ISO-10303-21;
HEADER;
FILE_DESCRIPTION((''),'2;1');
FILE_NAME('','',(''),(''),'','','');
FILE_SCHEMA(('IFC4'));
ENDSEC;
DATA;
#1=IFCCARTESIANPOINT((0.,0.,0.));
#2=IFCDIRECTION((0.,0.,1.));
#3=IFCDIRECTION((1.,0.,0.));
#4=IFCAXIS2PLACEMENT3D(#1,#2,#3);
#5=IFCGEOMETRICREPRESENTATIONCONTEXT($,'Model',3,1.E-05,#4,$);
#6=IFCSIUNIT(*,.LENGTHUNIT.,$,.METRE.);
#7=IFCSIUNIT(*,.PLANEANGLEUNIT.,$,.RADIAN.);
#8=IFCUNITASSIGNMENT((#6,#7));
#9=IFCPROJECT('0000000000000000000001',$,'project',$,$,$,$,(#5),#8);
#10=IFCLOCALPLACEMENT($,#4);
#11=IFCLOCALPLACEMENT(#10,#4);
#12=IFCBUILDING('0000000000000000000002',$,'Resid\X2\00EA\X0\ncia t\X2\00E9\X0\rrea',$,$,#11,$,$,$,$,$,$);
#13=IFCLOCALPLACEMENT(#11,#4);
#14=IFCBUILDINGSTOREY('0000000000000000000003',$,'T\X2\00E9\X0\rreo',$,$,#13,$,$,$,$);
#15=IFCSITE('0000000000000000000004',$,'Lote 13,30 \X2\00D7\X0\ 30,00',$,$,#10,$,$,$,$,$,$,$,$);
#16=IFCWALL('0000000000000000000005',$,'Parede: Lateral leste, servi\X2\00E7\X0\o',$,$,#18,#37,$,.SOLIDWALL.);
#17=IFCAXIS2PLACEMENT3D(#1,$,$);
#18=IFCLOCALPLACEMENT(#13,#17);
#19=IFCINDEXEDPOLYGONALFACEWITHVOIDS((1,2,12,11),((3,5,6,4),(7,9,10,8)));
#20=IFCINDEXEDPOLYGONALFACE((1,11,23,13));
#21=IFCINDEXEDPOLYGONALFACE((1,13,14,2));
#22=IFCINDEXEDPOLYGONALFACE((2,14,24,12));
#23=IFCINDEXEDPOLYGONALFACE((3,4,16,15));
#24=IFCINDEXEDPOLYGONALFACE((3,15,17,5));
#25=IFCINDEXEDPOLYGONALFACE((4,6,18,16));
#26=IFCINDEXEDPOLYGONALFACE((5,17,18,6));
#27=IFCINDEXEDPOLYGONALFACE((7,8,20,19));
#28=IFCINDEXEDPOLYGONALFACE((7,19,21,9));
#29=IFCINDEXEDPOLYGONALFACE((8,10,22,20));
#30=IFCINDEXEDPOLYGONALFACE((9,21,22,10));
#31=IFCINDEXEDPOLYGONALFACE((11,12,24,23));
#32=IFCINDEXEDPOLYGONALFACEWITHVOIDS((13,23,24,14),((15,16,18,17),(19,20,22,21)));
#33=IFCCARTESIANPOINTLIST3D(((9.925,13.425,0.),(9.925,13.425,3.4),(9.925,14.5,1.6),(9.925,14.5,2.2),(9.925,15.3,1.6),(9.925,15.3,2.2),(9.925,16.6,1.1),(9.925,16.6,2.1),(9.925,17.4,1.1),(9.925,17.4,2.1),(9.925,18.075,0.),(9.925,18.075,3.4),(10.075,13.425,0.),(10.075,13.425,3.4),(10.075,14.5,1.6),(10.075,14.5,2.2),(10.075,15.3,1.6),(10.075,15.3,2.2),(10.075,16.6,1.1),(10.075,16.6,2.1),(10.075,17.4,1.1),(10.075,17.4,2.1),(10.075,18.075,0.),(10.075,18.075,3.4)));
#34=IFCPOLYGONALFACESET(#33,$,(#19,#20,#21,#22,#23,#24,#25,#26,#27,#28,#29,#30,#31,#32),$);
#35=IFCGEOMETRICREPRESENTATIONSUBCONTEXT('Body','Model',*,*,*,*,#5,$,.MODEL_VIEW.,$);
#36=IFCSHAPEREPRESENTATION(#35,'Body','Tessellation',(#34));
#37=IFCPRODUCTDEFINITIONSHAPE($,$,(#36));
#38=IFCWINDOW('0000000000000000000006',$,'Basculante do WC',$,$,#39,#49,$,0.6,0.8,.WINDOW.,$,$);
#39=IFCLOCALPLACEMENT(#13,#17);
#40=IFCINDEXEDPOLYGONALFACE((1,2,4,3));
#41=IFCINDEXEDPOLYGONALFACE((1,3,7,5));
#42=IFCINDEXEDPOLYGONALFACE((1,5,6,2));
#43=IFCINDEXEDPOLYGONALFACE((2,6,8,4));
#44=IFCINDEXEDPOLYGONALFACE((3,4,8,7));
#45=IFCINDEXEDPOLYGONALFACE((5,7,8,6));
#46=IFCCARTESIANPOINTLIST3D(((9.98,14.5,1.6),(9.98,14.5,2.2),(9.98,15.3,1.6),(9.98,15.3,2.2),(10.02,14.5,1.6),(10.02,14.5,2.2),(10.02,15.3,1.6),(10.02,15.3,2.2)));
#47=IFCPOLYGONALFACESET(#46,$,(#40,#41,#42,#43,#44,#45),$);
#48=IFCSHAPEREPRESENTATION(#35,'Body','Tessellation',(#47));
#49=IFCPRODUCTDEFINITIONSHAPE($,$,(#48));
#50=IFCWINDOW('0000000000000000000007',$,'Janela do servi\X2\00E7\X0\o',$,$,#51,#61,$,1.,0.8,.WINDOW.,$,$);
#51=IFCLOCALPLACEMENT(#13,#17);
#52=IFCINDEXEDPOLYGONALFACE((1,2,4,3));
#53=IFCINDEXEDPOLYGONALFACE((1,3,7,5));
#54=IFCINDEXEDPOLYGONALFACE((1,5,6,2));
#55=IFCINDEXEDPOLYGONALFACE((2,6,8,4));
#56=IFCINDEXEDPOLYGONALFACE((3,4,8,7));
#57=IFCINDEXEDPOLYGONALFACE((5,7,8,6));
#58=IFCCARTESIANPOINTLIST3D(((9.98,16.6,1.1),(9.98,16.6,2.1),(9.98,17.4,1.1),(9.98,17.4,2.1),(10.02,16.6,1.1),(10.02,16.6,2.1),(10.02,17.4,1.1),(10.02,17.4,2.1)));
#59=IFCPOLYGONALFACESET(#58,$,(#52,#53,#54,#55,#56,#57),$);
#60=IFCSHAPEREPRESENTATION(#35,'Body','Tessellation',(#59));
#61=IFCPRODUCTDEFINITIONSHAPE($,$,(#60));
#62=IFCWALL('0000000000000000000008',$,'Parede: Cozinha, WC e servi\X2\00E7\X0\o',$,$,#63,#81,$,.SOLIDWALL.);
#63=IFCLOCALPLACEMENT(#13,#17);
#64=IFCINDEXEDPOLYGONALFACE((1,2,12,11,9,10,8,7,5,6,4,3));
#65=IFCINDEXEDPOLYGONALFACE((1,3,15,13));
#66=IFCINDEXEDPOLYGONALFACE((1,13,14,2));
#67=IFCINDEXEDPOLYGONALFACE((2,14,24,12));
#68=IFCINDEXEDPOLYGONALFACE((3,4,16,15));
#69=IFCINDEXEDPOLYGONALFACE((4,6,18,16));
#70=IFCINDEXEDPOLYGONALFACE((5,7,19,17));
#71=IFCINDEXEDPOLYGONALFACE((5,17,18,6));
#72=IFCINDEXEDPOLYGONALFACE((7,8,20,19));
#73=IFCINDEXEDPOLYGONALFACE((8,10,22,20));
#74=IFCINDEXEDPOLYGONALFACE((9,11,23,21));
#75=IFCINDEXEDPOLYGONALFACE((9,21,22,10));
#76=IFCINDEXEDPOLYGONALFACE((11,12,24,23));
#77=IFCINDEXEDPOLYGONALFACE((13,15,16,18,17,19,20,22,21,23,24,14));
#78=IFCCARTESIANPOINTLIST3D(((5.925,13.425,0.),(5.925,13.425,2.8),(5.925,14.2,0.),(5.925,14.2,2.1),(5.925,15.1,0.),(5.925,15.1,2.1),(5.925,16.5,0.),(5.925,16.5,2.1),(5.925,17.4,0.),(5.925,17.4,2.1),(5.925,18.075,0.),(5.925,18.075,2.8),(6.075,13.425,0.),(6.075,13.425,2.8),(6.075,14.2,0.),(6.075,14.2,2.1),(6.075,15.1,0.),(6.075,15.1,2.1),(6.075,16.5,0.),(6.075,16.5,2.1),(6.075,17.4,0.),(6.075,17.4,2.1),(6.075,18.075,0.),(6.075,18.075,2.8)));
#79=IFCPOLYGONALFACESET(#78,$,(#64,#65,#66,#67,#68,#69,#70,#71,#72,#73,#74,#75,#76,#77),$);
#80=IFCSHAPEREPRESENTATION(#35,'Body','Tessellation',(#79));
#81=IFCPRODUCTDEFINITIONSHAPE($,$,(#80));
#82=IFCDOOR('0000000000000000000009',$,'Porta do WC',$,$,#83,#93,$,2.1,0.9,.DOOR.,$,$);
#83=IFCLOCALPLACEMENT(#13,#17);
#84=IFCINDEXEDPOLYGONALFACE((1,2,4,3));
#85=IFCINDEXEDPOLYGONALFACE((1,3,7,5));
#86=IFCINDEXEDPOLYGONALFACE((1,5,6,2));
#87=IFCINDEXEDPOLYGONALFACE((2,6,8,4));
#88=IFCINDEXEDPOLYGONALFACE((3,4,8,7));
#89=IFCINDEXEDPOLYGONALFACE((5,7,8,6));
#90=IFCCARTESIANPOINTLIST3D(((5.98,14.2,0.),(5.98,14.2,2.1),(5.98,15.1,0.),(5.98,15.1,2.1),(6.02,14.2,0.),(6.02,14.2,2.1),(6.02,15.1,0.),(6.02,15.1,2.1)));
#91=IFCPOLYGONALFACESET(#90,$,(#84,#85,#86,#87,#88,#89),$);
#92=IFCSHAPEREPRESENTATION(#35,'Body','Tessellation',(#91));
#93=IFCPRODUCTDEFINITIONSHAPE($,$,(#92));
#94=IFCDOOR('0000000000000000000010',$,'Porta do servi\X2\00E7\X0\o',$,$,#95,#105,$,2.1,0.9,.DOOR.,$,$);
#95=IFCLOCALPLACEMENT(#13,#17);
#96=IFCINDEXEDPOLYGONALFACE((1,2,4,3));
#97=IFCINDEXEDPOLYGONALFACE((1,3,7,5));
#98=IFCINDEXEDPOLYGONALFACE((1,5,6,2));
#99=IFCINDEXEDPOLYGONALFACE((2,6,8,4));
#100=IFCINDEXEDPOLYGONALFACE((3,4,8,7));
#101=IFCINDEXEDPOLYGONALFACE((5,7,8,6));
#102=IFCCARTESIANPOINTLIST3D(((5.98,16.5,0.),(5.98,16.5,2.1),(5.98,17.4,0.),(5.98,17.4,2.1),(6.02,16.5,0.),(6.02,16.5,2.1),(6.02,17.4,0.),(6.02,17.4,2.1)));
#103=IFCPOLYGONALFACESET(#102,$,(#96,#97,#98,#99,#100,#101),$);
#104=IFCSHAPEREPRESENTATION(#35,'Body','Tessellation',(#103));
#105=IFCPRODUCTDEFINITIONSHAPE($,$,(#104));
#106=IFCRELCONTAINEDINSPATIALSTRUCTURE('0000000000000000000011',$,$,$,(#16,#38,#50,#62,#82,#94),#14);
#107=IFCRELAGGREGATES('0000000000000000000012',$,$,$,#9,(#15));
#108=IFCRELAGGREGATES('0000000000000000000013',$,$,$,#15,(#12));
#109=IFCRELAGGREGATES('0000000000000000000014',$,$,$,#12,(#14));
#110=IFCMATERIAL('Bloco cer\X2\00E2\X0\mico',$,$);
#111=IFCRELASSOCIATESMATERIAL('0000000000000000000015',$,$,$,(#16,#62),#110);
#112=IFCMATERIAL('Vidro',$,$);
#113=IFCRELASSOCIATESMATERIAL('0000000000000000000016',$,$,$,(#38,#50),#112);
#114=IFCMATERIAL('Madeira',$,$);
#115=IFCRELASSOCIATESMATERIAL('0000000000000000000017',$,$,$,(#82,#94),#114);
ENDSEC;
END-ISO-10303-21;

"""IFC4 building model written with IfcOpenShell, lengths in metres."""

from ifc_helpers import new_model, si_unit, frame, origin_with_axes, place, context, subcontext, project, spatial, line, indexed_curve, outline, extrude, material, element, fill, save


model = new_model("IFC4")

# Units and contexts
model_context = context("Model", 3, precision=1e-05, world=origin_with_axes())
body_context = subcontext(model_context, "Body", "Model", "MODEL_VIEW")
ifc_project = project(units=[si_unit("LENGTHUNIT", "METRE"), si_unit("PLANEANGLEUNIT", "RADIAN")], contexts=[model_context])

# Site, building, storey
site_placement = place(None, origin_with_axes())
site = spatial("IfcSite", under=ifc_project, at=site_placement, Name="Lote 13,30 × 30,00")
building_placement = place(site_placement, origin_with_axes())
building = spatial("IfcBuilding", under=site, at=building_placement, Name="Residência térrea")
storey_placement = place(building_placement, origin_with_axes())
storey = spatial("IfcBuildingStorey", under=building, at=storey_placement, Name="Térreo")

# Shared definitions
ifc_material_1 = material(Name="Concreto armado")

# Shared definitions
ifc_material_2 = material(Name="Bloco cerâmico")
ifc_material_3 = material(Name="Vidro")

# Wall, openings, windows
wall_1_placement = place(storey_placement, frame((9.925, 13.425, 0.0), z_axis=(0.0, 0.0, 1.0), x_axis=(1.0, 0.0, 0.0)))
wall_1 = element("IfcWall", 1, at=wall_1_placement, inside=storey, material=ifc_material_2, Name="Parede: Lateral leste, serviço", PredefinedType="SOLIDWALL", context=body_context, shape_type="SweptSolid", body=[
    extrude(outline(indexed_curve([(0.0, 0.0), (0.15, 0.0), (0.15, 4.65), (0.0, 4.65)], segments=[line(1, 2, 3, 4, 1)])), origin_with_axes(), (0.0, 0.0, 1.0), 3.4),
])
opening_1_placement = place(wall_1_placement, frame((-0.05, 1.075, 1.6), z_axis=(0.0, 0.0, 1.0), x_axis=(1.0, 0.0, 0.0)))
opening_1 = element("IfcOpeningElement", 2, at=opening_1_placement, cuts=wall_1, material=ifc_material_1, PredefinedType="OPENING", context=body_context, shape_type="SweptSolid", body=[
    extrude(outline(indexed_curve([(0.0, 0.0), (0.25, 0.0), (0.25, 0.8), (0.0, 0.8)], segments=[line(1, 2, 3, 4, 1)])), origin_with_axes(), (0.0, 0.0, 1.0), 0.6),
])
opening_2_placement = place(wall_1_placement, frame((-0.05, 3.175, 1.1), z_axis=(0.0, 0.0, 1.0), x_axis=(1.0, 0.0, 0.0)))
opening_2 = element("IfcOpeningElement", 3, at=opening_2_placement, cuts=wall_1, material=ifc_material_1, PredefinedType="OPENING", context=body_context, shape_type="SweptSolid", body=[
    extrude(outline(indexed_curve([(0.0, 0.0), (0.25, 0.0), (0.25, 0.8), (0.0, 0.8)], segments=[line(1, 2, 3, 4, 1)])), origin_with_axes(), (0.0, 0.0, 1.0), 1.0),
])
window_1_placement = place(storey_placement, frame((9.98, 14.5, 1.6), z_axis=(0.0, 0.0, 1.0), x_axis=(1.0, 0.0, 0.0)))
window_1 = element("IfcWindow", 4, at=window_1_placement, inside=storey, material=ifc_material_3, Name="Basculante do WC", OverallHeight=0.6, OverallWidth=0.8, PredefinedType="WINDOW", context=body_context, shape_type="SweptSolid", body=[
    extrude(outline(indexed_curve([(0.0, 0.0), (0.04, 0.0), (0.04, 0.8), (0.0, 0.8)], segments=[line(1, 2, 3, 4, 1)])), origin_with_axes(), (0.0, 0.0, 1.0), 0.6),
])
fill(opening_1, window_1)
window_2_placement = place(storey_placement, frame((9.98, 16.6, 1.1), z_axis=(0.0, 0.0, 1.0), x_axis=(1.0, 0.0, 0.0)))
window_2 = element("IfcWindow", 5, at=window_2_placement, inside=storey, material=ifc_material_3, Name="Janela do serviço", OverallHeight=1.0, OverallWidth=0.8, PredefinedType="WINDOW", context=body_context, shape_type="SweptSolid", body=[
    extrude(outline(indexed_curve([(0.0, 0.0), (0.04, 0.0), (0.04, 0.8), (0.0, 0.8)], segments=[line(1, 2, 3, 4, 1)])), origin_with_axes(), (0.0, 0.0, 1.0), 1.0),
])
fill(opening_2, window_2)

# Wall, openings, doors
wall_2_placement = place(storey_placement, frame((5.925, 13.425, 0.0), z_axis=(0.0, 0.0, 1.0), x_axis=(1.0, 0.0, 0.0)))
wall_2 = element("IfcWall", 6, at=wall_2_placement, inside=storey, material=ifc_material_2, Name="Parede: Cozinha, WC e serviço", PredefinedType="SOLIDWALL", context=body_context, shape_type="SweptSolid", body=[
    extrude(outline(indexed_curve([(0.0, 0.0), (0.15, 0.0), (0.15, 4.65), (0.0, 4.65)], segments=[line(1, 2, 3, 4, 1)])), origin_with_axes(), (0.0, 0.0, 1.0), 2.8),
])
opening_3_placement = place(wall_2_placement, frame((-0.05, 0.775, 0.0), z_axis=(0.0, 0.0, 1.0), x_axis=(1.0, 0.0, 0.0)))
opening_3 = element("IfcOpeningElement", 7, at=opening_3_placement, cuts=wall_2, material=ifc_material_1, PredefinedType="OPENING", context=body_context, shape_type="SweptSolid", body=[
    extrude(outline(indexed_curve([(0.0, 0.0), (0.25, 0.0), (0.25, 0.9), (0.0, 0.9)], segments=[line(1, 2, 3, 4, 1)])), origin_with_axes(), (0.0, 0.0, 1.0), 2.1),
])
opening_4_placement = place(wall_2_placement, frame((-0.05, 3.075, 0.0), z_axis=(0.0, 0.0, 1.0), x_axis=(1.0, 0.0, 0.0)))
opening_4 = element("IfcOpeningElement", 8, at=opening_4_placement, cuts=wall_2, material=ifc_material_1, PredefinedType="OPENING", context=body_context, shape_type="SweptSolid", body=[
    extrude(outline(indexed_curve([(0.0, 0.0), (0.25, 0.0), (0.25, 0.9), (0.0, 0.9)], segments=[line(1, 2, 3, 4, 1)])), origin_with_axes(), (0.0, 0.0, 1.0), 2.1),
])
ifc_material_4 = material(Name="Madeira")
door_1_placement = place(storey_placement, frame((5.98, 14.2, 0.0), z_axis=(0.0, 0.0, 1.0), x_axis=(1.0, 0.0, 0.0)))
door_1 = element("IfcDoor", 9, at=door_1_placement, inside=storey, material=ifc_material_4, Name="Porta do WC", OverallHeight=2.1, OverallWidth=0.9, PredefinedType="DOOR", context=body_context, shape_type="SweptSolid", body=[
    extrude(outline(indexed_curve([(0.0, 0.0), (0.04, 0.0), (0.04, 0.9), (0.0, 0.9)], segments=[line(1, 2, 3, 4, 1)])), origin_with_axes(), (0.0, 0.0, 1.0), 2.1),
])
fill(opening_3, door_1)
door_2_placement = place(storey_placement, frame((5.98, 16.5, 0.0), z_axis=(0.0, 0.0, 1.0), x_axis=(1.0, 0.0, 0.0)))
door_2 = element("IfcDoor", 10, at=door_2_placement, inside=storey, material=ifc_material_4, Name="Porta do serviço", OverallHeight=2.1, OverallWidth=0.9, PredefinedType="DOOR", context=body_context, shape_type="SweptSolid", body=[
    extrude(outline(indexed_curve([(0.0, 0.0), (0.04, 0.0), (0.04, 0.9), (0.0, 0.9)], segments=[line(1, 2, 3, 4, 1)])), origin_with_axes(), (0.0, 0.0, 1.0), 2.1),
])
fill(opening_4, door_2)

save(model, "model.ifc")
